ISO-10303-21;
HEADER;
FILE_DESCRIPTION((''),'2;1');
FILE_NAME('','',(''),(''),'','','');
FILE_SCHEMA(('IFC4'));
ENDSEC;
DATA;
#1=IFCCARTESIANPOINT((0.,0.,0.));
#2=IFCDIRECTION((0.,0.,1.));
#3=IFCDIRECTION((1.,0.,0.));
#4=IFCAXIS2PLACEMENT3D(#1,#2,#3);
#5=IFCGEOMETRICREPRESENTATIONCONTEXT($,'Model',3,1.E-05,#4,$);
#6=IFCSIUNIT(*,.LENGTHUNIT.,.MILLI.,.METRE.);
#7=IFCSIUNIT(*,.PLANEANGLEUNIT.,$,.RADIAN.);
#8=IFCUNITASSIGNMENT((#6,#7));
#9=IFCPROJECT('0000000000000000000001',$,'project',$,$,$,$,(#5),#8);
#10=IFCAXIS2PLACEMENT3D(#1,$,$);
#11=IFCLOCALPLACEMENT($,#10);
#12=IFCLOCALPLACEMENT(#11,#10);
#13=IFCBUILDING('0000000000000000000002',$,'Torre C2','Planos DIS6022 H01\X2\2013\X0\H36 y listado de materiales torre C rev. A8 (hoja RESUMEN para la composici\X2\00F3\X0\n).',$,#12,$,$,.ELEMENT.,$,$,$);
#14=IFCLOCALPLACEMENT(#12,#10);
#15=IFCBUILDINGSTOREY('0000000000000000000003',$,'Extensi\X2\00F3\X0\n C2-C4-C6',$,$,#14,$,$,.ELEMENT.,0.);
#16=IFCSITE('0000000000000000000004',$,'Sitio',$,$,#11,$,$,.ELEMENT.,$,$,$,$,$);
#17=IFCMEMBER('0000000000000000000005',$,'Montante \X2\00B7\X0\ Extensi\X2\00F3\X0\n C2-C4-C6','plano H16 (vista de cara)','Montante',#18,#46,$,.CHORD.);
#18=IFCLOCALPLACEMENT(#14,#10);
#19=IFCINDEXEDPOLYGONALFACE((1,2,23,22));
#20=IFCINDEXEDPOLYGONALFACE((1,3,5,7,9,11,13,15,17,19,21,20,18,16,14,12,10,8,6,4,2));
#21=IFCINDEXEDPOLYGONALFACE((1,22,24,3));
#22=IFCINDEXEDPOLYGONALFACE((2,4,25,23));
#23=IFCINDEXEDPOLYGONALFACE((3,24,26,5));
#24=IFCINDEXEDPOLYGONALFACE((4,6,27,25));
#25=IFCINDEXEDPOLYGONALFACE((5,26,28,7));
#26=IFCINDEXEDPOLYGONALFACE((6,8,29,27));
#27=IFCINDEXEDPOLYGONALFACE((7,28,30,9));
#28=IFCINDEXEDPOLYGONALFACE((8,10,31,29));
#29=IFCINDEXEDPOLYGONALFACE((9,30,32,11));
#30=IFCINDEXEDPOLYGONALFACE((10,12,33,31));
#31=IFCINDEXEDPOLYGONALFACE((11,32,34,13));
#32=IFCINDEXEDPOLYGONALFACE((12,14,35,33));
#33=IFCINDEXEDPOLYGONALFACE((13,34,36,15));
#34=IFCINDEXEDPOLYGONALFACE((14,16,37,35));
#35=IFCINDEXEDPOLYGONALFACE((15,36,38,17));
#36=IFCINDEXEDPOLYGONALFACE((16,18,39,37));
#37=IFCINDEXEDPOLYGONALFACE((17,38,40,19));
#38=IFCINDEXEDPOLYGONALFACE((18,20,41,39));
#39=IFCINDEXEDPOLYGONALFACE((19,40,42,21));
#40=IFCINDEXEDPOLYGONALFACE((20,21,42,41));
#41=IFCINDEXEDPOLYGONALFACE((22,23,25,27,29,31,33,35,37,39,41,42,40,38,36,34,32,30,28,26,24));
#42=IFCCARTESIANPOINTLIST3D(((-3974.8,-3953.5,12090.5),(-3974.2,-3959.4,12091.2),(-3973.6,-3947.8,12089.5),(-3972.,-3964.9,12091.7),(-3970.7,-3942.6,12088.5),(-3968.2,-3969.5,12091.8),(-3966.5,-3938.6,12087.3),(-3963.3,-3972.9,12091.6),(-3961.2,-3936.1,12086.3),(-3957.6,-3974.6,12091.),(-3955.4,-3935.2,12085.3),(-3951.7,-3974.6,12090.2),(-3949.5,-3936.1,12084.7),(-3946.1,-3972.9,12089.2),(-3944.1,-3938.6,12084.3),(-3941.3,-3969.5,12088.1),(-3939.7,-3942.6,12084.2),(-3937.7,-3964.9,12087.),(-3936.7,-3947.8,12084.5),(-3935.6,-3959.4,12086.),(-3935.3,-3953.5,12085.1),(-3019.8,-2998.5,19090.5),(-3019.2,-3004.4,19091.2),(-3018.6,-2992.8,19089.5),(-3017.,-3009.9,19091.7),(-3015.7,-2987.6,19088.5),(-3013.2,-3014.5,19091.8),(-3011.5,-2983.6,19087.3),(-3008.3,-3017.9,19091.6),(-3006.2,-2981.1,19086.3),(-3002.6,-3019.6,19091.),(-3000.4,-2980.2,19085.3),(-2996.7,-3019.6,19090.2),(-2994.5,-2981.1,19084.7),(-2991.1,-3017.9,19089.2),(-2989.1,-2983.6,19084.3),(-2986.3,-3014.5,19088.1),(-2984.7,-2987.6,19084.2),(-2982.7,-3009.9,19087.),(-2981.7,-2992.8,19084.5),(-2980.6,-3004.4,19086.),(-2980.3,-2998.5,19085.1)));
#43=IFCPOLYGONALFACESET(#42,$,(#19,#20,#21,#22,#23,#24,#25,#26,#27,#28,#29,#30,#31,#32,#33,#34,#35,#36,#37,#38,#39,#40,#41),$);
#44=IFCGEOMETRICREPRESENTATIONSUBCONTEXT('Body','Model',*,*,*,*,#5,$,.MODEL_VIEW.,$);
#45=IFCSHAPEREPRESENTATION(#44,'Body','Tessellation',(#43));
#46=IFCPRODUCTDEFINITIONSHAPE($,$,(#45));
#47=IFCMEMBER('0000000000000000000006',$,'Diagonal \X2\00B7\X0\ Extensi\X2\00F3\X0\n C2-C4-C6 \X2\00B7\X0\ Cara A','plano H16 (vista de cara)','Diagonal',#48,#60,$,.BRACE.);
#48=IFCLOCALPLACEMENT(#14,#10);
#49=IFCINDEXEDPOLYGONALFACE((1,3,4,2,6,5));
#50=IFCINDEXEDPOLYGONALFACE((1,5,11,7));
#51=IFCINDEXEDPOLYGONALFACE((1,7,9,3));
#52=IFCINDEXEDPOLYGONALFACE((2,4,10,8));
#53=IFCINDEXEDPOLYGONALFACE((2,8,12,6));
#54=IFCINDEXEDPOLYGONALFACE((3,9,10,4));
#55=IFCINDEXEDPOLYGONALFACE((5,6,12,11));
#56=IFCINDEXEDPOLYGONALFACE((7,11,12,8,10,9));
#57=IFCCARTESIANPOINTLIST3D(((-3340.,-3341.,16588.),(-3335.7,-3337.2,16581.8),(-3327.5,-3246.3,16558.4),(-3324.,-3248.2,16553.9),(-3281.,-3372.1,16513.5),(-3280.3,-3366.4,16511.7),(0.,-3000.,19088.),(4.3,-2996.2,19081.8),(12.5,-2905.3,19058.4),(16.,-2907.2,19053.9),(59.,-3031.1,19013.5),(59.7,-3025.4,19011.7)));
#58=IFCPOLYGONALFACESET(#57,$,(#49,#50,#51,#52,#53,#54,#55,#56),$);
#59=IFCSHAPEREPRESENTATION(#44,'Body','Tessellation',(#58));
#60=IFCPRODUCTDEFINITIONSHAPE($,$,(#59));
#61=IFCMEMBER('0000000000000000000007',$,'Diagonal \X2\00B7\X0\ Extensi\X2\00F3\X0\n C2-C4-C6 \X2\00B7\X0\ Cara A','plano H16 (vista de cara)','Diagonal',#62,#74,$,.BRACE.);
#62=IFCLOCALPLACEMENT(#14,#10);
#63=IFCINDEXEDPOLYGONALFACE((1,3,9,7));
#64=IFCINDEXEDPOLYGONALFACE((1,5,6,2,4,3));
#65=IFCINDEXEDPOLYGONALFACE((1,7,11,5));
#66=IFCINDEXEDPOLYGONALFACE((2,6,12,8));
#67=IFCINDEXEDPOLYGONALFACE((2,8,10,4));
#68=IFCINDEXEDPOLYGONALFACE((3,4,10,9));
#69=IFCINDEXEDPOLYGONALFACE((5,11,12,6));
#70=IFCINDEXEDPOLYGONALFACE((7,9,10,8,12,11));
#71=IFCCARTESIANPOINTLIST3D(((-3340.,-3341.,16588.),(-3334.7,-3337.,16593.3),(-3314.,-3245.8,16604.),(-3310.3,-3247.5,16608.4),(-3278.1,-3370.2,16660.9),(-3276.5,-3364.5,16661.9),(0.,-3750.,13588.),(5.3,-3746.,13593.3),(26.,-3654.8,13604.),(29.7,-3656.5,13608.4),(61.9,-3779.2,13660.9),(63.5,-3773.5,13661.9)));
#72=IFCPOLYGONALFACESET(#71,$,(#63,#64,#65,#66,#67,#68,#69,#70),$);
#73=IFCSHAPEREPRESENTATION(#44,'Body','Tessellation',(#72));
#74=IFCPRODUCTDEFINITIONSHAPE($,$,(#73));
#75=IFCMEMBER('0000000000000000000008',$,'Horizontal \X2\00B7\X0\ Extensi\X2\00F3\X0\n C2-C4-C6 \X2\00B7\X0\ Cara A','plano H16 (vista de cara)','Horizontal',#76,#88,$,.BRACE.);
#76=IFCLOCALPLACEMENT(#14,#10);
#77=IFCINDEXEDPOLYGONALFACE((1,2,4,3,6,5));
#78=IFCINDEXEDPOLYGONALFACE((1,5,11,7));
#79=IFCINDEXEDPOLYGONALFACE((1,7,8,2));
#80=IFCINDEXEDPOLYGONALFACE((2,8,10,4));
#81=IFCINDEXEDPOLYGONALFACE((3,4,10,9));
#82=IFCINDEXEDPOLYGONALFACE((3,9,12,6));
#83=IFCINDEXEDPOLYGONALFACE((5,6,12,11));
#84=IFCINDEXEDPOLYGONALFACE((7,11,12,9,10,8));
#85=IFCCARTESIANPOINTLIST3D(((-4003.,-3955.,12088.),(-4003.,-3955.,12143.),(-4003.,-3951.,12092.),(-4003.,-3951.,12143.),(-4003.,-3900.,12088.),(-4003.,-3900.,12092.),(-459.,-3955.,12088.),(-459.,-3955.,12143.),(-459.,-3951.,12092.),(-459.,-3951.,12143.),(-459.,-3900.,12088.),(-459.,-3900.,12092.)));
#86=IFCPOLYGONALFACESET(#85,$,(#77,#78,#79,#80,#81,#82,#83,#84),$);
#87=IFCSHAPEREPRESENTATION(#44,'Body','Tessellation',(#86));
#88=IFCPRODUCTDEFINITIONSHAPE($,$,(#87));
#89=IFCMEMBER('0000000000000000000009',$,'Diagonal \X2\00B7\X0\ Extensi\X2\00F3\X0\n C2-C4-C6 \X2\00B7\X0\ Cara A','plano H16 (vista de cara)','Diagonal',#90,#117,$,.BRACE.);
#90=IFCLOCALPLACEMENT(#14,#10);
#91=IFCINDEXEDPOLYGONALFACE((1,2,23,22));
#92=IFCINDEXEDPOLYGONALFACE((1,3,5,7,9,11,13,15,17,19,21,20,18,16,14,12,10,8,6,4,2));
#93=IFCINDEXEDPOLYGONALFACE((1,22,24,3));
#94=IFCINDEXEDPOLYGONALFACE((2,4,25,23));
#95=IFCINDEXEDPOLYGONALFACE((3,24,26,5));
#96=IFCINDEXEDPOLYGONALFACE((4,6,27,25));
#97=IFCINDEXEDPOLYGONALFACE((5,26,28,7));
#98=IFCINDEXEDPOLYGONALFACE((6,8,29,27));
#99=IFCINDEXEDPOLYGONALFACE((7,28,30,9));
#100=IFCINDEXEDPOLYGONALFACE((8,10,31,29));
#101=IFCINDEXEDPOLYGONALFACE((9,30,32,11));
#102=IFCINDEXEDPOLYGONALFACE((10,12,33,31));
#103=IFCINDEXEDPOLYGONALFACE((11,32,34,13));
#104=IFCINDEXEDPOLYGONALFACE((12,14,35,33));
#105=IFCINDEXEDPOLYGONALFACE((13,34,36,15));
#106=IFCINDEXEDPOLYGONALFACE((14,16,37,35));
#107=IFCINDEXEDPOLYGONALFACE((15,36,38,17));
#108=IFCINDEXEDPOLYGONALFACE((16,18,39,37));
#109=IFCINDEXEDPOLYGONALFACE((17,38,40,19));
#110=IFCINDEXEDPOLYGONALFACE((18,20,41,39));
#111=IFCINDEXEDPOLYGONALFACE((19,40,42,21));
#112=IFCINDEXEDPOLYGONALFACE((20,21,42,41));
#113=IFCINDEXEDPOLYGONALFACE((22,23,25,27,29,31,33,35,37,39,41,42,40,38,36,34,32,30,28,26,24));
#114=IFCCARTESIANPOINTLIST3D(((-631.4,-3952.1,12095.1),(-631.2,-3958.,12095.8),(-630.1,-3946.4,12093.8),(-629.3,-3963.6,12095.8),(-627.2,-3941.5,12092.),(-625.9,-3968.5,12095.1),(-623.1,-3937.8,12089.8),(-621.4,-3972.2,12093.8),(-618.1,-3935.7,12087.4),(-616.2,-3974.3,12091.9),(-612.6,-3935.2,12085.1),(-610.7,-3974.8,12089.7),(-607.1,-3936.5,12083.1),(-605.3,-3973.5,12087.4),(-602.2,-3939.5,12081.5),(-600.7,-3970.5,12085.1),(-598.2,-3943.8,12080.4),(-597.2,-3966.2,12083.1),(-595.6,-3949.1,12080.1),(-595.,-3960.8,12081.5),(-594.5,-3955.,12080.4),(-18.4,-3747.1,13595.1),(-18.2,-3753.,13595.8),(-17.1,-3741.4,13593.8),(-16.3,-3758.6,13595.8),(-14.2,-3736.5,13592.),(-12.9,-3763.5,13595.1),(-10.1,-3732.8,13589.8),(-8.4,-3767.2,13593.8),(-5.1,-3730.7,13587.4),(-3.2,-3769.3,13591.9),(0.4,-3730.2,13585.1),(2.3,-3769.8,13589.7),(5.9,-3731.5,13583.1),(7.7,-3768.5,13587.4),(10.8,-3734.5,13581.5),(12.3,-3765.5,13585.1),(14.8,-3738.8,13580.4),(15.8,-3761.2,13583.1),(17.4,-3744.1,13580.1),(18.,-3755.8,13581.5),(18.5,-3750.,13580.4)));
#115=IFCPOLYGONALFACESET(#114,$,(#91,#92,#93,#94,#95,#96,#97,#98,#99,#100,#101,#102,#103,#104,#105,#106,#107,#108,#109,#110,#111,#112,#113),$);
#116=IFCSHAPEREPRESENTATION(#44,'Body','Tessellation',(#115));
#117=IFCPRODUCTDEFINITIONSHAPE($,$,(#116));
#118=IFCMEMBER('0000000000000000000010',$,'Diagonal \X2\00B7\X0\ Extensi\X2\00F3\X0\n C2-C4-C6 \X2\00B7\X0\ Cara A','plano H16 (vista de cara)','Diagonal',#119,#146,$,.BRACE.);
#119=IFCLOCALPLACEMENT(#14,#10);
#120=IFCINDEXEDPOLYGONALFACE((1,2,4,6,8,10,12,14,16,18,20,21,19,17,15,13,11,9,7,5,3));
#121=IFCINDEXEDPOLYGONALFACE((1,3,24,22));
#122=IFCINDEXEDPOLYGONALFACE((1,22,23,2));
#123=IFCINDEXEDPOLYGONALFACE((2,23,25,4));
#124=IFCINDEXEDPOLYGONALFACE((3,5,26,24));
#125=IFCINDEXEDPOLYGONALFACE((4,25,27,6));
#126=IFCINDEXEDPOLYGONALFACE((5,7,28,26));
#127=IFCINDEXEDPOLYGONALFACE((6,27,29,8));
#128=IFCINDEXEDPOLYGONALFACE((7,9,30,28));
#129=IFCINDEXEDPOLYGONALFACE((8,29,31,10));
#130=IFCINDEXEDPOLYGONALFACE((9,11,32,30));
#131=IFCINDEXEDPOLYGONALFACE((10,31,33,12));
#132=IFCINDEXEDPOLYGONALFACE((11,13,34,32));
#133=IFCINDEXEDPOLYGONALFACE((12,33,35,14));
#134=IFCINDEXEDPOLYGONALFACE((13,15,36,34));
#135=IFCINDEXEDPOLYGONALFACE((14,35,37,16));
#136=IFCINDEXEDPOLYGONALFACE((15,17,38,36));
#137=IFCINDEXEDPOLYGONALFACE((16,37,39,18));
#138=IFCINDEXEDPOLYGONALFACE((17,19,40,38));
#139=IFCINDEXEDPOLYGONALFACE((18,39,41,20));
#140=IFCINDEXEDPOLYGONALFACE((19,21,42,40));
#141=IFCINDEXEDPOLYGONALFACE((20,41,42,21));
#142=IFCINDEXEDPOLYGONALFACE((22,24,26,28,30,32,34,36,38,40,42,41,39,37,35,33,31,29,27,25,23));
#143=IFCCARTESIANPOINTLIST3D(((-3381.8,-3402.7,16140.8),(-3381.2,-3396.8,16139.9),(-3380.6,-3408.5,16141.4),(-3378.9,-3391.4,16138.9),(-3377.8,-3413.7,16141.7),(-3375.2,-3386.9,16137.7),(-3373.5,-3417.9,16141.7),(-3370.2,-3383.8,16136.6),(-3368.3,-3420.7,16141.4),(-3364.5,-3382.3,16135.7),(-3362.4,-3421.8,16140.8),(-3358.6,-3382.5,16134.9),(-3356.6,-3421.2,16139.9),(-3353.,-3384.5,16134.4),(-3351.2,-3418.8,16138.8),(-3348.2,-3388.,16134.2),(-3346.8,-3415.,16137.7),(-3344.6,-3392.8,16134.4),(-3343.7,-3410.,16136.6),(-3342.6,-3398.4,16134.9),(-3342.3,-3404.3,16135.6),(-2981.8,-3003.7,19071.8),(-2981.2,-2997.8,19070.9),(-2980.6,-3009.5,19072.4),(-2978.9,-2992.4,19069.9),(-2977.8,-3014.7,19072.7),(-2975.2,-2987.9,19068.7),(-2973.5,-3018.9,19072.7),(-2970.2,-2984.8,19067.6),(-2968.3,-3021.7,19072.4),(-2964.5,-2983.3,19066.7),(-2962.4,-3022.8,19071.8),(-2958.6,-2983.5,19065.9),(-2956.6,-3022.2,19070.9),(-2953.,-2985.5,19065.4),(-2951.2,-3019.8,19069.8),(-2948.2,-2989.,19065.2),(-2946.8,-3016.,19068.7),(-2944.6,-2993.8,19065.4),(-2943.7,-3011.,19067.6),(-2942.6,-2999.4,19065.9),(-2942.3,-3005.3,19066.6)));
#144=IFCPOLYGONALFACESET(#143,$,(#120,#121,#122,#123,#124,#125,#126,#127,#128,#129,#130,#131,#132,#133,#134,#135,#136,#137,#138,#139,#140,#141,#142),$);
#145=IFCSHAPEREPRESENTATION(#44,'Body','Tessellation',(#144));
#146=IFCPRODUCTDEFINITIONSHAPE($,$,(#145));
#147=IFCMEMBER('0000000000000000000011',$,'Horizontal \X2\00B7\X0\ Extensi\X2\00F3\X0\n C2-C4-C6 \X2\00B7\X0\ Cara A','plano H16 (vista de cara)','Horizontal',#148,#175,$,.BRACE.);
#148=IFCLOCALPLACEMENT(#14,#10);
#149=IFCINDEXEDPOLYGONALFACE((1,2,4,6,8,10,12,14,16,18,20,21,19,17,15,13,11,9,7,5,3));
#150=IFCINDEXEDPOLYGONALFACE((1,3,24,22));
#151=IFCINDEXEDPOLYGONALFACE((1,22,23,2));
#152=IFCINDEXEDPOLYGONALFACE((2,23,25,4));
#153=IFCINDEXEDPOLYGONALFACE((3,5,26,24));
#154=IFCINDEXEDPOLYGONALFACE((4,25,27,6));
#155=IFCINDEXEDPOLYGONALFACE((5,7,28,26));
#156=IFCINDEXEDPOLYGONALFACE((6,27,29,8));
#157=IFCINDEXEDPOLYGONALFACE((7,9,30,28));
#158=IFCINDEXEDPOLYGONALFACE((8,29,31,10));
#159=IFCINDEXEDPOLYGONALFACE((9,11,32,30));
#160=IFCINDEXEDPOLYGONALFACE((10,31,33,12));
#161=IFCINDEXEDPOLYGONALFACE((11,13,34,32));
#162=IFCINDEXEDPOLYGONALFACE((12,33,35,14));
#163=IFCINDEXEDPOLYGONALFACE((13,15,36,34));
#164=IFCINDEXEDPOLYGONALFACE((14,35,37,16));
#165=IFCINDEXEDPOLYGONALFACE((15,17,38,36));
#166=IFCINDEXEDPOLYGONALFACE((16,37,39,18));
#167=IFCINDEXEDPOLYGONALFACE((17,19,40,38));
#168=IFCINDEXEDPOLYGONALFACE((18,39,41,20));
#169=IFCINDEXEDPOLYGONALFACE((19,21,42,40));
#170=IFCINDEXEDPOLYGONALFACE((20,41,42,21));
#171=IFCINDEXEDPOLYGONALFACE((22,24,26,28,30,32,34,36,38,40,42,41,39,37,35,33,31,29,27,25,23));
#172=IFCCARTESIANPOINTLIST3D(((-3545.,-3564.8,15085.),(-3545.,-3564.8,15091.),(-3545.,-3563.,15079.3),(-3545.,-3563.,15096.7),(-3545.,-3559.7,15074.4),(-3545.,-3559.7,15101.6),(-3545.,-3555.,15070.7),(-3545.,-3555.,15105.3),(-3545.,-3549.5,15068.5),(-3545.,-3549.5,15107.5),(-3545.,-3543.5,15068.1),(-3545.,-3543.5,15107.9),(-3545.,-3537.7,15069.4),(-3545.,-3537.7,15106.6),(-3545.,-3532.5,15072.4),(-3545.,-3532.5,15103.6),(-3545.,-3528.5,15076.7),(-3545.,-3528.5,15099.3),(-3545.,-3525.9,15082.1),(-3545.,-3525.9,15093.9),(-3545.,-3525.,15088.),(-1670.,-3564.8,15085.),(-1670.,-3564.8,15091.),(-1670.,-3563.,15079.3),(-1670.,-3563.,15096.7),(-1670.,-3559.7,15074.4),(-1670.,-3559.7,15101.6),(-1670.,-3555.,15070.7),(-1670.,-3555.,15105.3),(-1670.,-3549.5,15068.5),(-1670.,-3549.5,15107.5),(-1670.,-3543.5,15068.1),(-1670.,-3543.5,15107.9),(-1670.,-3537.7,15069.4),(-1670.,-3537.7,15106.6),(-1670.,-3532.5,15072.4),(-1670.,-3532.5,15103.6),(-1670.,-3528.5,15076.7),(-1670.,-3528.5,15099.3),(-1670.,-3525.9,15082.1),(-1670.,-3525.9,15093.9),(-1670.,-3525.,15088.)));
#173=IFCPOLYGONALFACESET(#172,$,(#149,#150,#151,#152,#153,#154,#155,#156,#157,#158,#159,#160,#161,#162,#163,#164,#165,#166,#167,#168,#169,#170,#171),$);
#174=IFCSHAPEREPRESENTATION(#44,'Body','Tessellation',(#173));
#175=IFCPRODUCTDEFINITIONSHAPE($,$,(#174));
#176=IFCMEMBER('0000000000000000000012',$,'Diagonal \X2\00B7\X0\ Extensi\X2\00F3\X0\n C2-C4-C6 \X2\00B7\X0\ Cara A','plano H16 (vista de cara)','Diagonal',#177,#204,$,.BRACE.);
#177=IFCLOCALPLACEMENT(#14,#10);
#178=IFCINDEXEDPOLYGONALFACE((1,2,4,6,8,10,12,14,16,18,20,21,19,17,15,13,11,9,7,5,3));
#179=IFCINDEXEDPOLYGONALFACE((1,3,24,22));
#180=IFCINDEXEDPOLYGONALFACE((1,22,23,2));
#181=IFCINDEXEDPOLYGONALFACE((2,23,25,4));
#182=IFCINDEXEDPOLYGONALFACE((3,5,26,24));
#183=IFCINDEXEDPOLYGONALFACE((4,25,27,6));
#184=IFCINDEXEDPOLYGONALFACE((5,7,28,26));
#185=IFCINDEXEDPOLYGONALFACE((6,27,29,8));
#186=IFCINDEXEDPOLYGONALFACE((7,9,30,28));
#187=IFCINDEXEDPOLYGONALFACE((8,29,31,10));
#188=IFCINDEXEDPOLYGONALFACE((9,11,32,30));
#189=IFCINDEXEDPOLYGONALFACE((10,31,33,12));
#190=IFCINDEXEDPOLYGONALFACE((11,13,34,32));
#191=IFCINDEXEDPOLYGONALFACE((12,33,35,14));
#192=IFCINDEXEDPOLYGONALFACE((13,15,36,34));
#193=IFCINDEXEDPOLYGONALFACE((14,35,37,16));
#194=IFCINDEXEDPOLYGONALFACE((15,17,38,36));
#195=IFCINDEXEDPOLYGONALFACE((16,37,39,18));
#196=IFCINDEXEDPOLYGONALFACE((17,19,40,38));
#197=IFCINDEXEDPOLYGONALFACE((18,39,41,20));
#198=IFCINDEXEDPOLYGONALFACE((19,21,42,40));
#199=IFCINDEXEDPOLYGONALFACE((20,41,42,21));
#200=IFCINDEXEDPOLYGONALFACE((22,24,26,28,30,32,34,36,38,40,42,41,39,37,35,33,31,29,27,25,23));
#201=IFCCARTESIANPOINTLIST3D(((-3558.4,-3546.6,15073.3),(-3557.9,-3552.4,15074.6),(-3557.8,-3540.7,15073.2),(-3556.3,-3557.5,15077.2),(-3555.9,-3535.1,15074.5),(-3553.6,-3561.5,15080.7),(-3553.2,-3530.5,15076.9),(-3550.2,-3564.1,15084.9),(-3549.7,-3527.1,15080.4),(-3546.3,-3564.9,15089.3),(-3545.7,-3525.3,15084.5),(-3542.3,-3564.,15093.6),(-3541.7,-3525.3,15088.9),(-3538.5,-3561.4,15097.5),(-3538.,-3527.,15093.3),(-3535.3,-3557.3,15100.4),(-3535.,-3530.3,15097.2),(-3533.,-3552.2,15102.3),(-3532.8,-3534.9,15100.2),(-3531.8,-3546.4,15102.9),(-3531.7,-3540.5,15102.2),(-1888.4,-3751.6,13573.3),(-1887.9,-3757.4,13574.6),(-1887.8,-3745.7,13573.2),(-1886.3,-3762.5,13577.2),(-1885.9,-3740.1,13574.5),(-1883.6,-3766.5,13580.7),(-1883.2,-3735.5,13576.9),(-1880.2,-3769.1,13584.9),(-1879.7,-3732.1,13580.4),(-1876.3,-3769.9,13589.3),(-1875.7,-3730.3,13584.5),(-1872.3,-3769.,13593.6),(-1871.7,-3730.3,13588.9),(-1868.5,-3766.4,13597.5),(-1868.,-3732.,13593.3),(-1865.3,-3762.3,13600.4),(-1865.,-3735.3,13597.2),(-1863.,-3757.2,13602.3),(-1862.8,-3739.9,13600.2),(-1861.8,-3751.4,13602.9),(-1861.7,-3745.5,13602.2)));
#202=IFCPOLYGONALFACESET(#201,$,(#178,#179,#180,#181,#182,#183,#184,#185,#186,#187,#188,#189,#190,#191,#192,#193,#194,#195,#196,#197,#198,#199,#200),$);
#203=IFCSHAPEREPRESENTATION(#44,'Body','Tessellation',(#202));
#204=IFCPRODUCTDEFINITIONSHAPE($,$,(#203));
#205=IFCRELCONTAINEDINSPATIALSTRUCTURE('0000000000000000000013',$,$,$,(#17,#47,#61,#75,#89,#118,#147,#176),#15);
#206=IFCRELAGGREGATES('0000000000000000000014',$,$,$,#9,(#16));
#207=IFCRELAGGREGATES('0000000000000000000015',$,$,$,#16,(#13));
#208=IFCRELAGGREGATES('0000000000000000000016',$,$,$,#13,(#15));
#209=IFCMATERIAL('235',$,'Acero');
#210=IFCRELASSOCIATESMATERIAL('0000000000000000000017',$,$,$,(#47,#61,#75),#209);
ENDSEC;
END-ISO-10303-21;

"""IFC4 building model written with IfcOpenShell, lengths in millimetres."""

from ifc_helpers import new_model, si_unit, frame, frame_2d, origin, origin_with_axes, place, context, subcontext, project, spatial, circle, l_section, extrude, material, element, save


model = new_model("IFC4")

# Units and contexts
model_context = context("Model", 3, precision=1e-05, world=origin_with_axes())
body_context = subcontext(model_context, "Body", "Model", "MODEL_VIEW")
ifc_project = project(units=[si_unit("LENGTHUNIT", "METRE", prefix="MILLI"), si_unit("PLANEANGLEUNIT", "RADIAN")], contexts=[model_context])

# Site, building, storey
site_placement = place(None, origin())
site = spatial("IfcSite", under=ifc_project, at=site_placement, Name="Sitio", CompositionType="ELEMENT")
building_placement = place(site_placement, origin())
building = spatial("IfcBuilding", under=site, at=building_placement, Name="Torre C2", Description="Planos DIS6022 H01–H36 y listado de materiales torre C rev. A8 (hoja RESUMEN para la composición).", CompositionType="ELEMENT")
storey_placement = place(building_placement, origin())
storey = spatial("IfcBuildingStorey", under=building, at=storey_placement, Name="Extensión C2-C4-C6", CompositionType="ELEMENT", Elevation=0.0)

# Members
member_1_placement = place(storey_placement, frame((-3000.0, -3000.0, 19088.0), z_axis=(-0.133958, -0.133958, -0.981891), x_axis=(-0.018108, 0.990987, -0.132728)))
element("IfcMember", 1, at=member_1_placement, inside=storey, Name="Montante · Extensión C2-C4-C6", Description="plano H16 (vista de cara)", ObjectType="Montante", PredefinedType="CHORD", context=body_context, shape_type="SweptSolid", body=[
    extrude(circle(Radius=20.0), None, (0.0, 0.0, 1.0), 7129.1),
])
ifc_material_1 = material(Name="235", Category="Acero")
member_2_placement = place(storey_placement, frame((0.0, -3000.0, 19088.0), z_axis=(-0.797914, -0.081464, -0.597241), x_axis=(0.124785, 0.947037, -0.295888)))
element("IfcMember", 2, at=member_2_placement, inside=storey, material=ifc_material_1, Name="Diagonal · Extensión C2-C4-C6 · Cara A", Description="plano H16 (vista de cara)", ObjectType="Diagonal", PredefinedType="BRACE", context=body_context, shape_type="SweptSolid", body=[
    extrude(l_section(Depth=100.0, Width=100.0, Thickness=6.0, at=frame_2d((50.0, 50.0))), None, (0.0, 0.0, 1.0), 4185.9),
])
member_3_placement = place(storey_placement, frame((-3340.0, -3341.0, 16588.0), z_axis=(0.74089, -0.090726, -0.66547), x_axis=(0.260225, 0.952216, 0.159898)))
element("IfcMember", 3, at=member_3_placement, inside=storey, material=ifc_material_1, Name="Diagonal · Extensión C2-C4-C6 · Cara A", Description="plano H16 (vista de cara)", ObjectType="Diagonal", PredefinedType="BRACE", context=body_context, shape_type="SweptSolid", body=[
    extrude(l_section(Depth=100.0, Width=100.0, Thickness=6.0, at=frame_2d((50.0, 50.0))), None, (0.0, 0.0, 1.0), 4508.1),
])
member_4_placement = place(storey_placement, frame((-4003.0, -3955.0, 12088.0), z_axis=(1.0, 0.0, 0.0), x_axis=(0.0, 1.0, 0.0)))
element("IfcMember", 4, at=member_4_placement, inside=storey, material=ifc_material_1, Name="Horizontal · Extensión C2-C4-C6 · Cara A", Description="plano H16 (vista de cara)", ObjectType="Horizontal", PredefinedType="BRACE", context=body_context, shape_type="SweptSolid", body=[
    extrude(l_section(Depth=55.0, Width=55.0, Thickness=4.0, at=frame_2d((27.5, 27.5))), None, (0.0, 0.0, 1.0), 3544.0),
])
member_5_placement = place(storey_placement, frame((0.0, -3750.0, 13588.0), z_axis=(-0.375305, -0.12551, -0.918365), x_axis=(0.02144, 0.989349, -0.143973)))
element("IfcMember", 5, at=member_5_placement, inside=storey, Name="Diagonal · Extensión C2-C4-C6 · Cara A", Description="plano H16 (vista de cara)", ObjectType="Diagonal", PredefinedType="BRACE", context=body_context, shape_type="SweptSolid", body=[
    extrude(circle(Radius=20.0), None, (0.0, 0.0, 1.0), 1633.3),
])
member_6_placement = place(storey_placement, frame((-2962.0, -3003.0, 19069.0), z_axis=(-0.134005, -0.13367, -0.981924), x_axis=(0.689696, 0.698925, -0.18927)))
element("IfcMember", 6, at=member_6_placement, inside=storey, Name="Diagonal · Extensión C2-C4-C6 · Cara A", Description="plano H16 (vista de cara)", ObjectType="Diagonal", PredefinedType="BRACE", context=body_context, shape_type="SweptSolid", body=[
    extrude(circle(Radius=20.0), None, (0.0, 0.0, 1.0), 2985.0),
])
member_7_placement = place(storey_placement, frame((-1670.0, -3545.0, 15088.0), z_axis=(-1.0, 0.0, 0.0), x_axis=(0.0, 1.0, 0.0)))
element("IfcMember", 7, at=member_7_placement, inside=storey, Name="Horizontal · Extensión C2-C4-C6 · Cara A", Description="plano H16 (vista de cara)", ObjectType="Horizontal", PredefinedType="BRACE", context=body_context, shape_type="SweptSolid", body=[
    extrude(circle(Radius=20.0), None, (0.0, 0.0, 1.0), 1875.0),
])
member_8_placement = place(storey_placement, frame((-3545.0, -3545.0, 15088.0), z_axis=(0.740875, -0.090946, -0.665457), x_axis=(0.347628, 0.899679, 0.264069)))
element("IfcMember", 8, at=member_8_placement, inside=storey, Name="Diagonal · Extensión C2-C4-C6 · Cara A", Description="plano H16 (vista de cara)", ObjectType="Diagonal", PredefinedType="BRACE", context=body_context, shape_type="SweptSolid", body=[
    extrude(circle(Radius=20.0), None, (0.0, 0.0, 1.0), 2254.1),
])

save(model, "model.ifc")
